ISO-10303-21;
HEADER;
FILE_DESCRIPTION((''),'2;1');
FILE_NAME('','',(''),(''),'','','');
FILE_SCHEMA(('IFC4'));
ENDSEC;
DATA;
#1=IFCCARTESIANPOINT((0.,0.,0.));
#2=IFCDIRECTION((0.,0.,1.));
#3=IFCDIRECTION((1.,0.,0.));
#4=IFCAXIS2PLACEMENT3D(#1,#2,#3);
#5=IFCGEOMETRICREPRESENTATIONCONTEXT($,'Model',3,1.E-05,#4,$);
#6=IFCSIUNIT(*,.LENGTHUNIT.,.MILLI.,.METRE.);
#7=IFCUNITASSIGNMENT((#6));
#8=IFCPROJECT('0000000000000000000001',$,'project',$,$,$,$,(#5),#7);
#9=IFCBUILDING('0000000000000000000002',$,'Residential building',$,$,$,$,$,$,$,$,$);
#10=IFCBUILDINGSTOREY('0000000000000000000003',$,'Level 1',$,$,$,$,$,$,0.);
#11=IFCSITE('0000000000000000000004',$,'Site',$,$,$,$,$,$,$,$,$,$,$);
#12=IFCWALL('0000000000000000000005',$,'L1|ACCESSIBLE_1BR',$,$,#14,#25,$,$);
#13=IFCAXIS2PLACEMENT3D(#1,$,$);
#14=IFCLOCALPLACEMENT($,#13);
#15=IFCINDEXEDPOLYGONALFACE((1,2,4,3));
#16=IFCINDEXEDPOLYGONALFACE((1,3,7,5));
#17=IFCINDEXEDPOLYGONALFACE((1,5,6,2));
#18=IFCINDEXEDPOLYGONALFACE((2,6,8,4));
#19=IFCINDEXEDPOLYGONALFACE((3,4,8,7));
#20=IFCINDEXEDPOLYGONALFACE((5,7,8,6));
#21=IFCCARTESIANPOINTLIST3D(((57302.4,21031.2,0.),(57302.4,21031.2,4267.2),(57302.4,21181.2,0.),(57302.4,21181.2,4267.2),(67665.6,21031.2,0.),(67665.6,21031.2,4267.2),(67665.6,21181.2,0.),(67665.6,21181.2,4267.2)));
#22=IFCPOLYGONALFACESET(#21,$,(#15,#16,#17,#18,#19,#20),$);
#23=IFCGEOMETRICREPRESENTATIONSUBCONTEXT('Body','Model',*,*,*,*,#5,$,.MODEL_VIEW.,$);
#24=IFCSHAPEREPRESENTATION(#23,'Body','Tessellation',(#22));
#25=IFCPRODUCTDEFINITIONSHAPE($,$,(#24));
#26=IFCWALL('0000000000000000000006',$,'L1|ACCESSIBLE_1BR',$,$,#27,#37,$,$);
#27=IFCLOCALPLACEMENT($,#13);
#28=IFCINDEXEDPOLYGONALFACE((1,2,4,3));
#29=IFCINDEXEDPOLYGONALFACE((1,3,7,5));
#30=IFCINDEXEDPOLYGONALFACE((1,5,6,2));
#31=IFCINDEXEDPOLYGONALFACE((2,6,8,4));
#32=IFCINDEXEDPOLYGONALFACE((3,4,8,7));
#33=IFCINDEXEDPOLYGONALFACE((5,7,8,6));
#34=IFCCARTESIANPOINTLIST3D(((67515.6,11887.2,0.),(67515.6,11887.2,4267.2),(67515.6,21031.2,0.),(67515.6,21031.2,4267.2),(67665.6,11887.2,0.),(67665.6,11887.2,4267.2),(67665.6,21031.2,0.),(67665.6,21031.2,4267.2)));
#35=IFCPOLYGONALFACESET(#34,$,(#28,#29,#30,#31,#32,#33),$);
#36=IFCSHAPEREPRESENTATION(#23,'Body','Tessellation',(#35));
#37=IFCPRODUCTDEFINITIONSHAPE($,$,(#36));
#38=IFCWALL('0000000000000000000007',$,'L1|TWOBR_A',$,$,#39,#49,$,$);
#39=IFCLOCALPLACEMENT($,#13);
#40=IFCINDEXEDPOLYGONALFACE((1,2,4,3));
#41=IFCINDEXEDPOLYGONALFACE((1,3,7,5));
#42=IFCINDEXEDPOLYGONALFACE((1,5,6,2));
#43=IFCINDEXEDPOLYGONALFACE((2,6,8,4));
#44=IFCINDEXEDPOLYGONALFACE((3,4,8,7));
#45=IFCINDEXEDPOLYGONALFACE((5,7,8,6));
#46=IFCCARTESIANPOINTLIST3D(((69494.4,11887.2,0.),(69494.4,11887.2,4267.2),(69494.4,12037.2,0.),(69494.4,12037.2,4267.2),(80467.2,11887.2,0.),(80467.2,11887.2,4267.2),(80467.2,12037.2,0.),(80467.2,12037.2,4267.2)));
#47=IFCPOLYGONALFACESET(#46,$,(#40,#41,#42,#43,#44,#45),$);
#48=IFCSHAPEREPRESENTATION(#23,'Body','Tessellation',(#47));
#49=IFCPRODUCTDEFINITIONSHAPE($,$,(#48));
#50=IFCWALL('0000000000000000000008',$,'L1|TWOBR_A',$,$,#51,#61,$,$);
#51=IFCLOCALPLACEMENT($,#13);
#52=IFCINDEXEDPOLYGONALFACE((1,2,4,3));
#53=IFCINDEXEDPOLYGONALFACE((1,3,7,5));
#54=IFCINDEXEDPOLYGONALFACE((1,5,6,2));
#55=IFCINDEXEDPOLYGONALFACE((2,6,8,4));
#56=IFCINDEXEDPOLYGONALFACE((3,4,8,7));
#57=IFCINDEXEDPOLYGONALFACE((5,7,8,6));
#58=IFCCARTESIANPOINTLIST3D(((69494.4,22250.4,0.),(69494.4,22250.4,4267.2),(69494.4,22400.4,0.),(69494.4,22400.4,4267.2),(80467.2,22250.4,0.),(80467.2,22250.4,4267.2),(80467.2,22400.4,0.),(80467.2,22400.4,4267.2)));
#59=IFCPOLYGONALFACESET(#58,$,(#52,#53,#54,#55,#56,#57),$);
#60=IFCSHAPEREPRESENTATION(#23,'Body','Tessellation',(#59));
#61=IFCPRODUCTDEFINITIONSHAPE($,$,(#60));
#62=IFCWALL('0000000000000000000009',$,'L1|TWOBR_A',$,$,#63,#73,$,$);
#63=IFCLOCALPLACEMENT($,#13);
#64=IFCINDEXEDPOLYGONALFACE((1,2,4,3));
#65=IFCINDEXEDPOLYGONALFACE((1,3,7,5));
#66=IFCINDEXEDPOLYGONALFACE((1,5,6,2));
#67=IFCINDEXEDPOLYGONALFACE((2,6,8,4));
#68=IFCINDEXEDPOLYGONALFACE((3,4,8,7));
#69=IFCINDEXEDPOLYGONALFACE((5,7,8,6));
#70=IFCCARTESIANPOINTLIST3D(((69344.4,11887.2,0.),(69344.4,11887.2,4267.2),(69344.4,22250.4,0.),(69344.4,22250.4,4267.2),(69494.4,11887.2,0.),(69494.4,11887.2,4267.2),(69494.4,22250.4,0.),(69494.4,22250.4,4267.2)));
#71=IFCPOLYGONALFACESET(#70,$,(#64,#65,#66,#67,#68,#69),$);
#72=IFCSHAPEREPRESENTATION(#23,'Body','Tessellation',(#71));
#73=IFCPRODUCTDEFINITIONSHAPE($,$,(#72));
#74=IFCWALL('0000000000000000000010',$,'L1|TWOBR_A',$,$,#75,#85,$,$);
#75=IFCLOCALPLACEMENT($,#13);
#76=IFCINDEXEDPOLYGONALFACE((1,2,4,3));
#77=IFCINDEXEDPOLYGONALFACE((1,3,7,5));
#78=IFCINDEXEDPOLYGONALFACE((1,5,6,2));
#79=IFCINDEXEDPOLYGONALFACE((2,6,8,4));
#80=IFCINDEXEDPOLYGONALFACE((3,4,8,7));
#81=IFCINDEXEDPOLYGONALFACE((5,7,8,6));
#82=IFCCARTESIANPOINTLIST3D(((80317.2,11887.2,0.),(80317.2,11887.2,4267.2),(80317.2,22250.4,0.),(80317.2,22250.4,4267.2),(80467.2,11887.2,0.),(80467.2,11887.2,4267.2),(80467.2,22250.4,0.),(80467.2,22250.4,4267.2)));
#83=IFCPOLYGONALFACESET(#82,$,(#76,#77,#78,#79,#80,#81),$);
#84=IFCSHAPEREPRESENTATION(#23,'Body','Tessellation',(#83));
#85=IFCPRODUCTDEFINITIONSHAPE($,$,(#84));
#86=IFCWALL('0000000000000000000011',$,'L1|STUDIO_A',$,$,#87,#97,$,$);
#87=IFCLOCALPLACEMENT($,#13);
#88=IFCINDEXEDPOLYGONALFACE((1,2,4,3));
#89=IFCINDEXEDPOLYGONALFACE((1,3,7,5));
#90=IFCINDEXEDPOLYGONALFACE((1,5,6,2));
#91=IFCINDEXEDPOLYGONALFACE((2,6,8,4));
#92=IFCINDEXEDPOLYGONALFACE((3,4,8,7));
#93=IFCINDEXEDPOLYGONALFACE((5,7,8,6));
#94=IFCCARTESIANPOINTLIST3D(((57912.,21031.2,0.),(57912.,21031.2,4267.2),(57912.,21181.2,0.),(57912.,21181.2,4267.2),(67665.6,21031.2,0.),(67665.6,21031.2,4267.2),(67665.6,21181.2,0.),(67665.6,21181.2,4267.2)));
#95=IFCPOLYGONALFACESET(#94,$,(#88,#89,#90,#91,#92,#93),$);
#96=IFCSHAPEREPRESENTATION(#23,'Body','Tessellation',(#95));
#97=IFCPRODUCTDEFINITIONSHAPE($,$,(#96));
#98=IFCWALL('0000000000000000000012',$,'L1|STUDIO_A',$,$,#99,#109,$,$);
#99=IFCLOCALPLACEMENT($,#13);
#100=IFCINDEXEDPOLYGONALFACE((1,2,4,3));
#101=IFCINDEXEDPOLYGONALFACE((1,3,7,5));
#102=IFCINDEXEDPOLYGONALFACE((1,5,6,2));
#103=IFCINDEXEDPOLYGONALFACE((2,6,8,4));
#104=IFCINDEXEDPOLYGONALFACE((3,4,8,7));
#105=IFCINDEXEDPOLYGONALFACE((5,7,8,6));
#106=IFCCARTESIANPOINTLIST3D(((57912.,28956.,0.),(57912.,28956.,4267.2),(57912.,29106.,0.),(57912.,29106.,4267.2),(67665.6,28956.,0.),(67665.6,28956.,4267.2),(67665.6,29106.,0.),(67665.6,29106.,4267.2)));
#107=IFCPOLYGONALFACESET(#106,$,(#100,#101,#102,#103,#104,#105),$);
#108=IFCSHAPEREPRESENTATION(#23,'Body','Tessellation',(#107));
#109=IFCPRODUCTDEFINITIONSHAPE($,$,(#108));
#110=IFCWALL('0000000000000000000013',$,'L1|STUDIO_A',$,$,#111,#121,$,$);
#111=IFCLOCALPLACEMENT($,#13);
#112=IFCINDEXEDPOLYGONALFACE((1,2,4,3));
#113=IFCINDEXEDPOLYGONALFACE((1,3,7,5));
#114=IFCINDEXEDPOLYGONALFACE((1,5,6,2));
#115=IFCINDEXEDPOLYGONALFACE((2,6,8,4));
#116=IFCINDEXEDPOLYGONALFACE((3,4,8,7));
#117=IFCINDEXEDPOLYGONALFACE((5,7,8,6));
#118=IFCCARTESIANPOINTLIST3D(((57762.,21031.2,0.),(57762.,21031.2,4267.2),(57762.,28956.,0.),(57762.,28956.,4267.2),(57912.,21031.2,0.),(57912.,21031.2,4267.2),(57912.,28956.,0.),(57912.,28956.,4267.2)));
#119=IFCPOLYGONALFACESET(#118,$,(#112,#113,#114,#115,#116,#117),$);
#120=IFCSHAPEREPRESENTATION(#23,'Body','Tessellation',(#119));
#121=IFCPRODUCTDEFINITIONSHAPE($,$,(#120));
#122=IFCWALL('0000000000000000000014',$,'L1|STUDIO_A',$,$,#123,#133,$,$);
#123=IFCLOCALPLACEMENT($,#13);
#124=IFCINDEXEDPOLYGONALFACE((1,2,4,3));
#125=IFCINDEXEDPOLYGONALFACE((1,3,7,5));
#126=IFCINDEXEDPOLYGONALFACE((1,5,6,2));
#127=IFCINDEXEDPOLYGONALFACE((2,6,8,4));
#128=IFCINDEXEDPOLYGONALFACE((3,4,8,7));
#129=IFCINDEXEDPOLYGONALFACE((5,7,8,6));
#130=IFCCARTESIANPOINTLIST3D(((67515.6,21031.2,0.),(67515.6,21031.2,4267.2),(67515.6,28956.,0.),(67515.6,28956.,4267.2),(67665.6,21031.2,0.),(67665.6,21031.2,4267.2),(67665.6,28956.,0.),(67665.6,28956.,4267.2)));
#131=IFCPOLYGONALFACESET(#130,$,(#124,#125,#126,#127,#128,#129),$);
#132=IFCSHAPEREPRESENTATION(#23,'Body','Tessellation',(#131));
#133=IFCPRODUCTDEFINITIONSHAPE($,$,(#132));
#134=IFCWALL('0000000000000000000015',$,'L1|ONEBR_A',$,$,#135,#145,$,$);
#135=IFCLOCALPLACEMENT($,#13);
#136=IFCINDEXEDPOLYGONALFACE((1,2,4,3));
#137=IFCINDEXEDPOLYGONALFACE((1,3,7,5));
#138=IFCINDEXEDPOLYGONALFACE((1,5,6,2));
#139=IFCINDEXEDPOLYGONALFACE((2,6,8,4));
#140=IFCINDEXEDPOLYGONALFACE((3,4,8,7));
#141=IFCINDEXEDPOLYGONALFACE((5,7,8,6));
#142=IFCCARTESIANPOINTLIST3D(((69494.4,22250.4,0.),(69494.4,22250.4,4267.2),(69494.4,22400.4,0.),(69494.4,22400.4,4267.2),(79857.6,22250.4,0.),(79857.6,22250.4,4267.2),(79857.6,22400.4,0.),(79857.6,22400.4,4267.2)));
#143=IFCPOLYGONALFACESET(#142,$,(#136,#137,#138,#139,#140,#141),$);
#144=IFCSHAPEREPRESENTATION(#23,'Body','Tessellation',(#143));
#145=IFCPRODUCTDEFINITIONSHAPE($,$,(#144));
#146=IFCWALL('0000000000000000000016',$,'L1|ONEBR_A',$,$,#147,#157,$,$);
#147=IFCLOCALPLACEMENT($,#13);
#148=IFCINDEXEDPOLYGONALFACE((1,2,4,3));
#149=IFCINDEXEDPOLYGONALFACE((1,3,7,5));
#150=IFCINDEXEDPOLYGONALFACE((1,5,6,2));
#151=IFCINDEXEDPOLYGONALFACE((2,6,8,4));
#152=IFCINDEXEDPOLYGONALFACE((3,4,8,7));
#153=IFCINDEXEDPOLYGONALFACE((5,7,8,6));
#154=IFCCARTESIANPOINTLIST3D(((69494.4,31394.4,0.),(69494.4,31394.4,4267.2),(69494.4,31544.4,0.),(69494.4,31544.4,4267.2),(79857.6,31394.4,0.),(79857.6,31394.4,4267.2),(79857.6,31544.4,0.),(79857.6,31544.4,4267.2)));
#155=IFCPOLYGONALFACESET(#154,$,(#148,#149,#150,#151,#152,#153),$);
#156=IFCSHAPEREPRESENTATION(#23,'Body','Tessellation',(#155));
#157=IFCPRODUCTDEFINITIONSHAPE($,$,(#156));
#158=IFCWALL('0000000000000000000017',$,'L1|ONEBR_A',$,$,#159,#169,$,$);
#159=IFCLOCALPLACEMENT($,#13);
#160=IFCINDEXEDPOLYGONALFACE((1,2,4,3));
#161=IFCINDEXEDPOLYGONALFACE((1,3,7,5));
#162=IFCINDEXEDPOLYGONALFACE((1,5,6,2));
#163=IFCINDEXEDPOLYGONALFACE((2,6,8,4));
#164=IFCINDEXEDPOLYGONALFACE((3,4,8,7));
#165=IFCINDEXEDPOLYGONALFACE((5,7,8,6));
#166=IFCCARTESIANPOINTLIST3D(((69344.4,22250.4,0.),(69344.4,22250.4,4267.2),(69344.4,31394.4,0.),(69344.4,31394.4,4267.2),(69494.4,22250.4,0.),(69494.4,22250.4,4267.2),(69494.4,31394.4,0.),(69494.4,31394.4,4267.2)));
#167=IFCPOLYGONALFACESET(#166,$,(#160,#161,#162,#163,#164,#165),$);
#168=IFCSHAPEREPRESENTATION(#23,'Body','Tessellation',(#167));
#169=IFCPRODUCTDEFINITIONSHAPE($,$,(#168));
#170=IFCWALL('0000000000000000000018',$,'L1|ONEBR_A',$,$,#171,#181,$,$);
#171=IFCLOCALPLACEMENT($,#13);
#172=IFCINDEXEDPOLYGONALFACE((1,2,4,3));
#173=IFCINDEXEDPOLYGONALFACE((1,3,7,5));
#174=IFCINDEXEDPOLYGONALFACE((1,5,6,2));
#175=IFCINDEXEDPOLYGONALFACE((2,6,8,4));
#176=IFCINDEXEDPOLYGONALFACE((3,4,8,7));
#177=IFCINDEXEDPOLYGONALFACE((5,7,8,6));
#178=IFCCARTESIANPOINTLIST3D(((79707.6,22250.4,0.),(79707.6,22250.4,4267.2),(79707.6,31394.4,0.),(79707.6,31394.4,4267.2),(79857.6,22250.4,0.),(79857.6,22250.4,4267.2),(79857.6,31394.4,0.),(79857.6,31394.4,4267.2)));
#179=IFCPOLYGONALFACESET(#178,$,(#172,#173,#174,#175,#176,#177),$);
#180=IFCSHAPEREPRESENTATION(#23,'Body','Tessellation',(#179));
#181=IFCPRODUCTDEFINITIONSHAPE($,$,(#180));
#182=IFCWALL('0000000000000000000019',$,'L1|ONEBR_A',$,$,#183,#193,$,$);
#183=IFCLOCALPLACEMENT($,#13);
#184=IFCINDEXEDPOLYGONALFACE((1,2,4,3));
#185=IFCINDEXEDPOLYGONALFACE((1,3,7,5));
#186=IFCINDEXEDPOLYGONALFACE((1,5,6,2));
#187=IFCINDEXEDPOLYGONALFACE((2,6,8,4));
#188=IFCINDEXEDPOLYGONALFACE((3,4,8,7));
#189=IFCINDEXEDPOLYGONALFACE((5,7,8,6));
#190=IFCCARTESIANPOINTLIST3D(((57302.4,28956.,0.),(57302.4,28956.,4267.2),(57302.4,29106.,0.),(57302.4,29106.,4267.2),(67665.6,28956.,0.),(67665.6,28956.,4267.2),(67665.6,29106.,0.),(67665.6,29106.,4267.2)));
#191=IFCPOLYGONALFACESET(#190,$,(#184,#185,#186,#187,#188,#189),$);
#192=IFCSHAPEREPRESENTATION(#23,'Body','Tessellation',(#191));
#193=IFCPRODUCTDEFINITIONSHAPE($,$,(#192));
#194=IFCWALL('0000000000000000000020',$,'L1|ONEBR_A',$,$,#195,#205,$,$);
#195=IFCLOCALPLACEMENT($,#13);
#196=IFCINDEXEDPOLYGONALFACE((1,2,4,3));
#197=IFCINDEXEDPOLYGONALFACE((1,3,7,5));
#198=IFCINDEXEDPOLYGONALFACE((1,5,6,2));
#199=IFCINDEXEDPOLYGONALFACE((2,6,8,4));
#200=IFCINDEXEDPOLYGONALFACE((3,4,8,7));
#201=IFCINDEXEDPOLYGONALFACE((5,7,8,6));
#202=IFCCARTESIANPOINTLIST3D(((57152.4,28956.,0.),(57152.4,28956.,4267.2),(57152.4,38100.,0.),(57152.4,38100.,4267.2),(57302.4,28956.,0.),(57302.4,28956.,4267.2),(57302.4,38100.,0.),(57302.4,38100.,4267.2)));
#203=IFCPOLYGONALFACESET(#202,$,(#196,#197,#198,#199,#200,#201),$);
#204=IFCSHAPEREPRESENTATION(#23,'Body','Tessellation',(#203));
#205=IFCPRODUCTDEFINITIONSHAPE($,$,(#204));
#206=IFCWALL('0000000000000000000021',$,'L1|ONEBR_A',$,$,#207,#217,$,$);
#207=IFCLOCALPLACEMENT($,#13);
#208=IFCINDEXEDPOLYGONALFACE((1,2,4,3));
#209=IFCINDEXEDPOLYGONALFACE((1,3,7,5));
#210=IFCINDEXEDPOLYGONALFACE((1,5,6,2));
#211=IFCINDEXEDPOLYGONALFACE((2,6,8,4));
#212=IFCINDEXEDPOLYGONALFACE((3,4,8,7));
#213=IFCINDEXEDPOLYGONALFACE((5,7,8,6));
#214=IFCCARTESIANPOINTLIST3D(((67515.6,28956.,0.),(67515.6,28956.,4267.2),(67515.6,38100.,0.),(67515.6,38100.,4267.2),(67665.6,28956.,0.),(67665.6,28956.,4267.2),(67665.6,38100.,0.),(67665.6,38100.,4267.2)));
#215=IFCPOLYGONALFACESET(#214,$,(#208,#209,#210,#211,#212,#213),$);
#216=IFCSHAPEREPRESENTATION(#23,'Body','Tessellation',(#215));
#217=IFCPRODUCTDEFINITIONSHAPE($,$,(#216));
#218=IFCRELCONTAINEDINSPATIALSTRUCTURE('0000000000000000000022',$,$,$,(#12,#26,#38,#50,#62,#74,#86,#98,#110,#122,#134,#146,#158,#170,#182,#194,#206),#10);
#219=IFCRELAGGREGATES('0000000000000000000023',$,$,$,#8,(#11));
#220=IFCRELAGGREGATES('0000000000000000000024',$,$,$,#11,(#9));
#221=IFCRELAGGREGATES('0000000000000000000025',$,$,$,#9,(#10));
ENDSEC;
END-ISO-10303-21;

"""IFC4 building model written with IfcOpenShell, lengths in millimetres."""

from ifc_helpers import new_model, si_unit, frame, origin_with_axes, place, context, subcontext, project, spatial, indexed_curve, outline, extrude, element, save


model = new_model("IFC4")

# Units and contexts
model_context = context("Model", 3, precision=1e-05, world=origin_with_axes())
body_context = subcontext(model_context, "Body", "Model", "MODEL_VIEW")
ifc_project = project(units=[si_unit("LENGTHUNIT", "METRE", prefix="MILLI")], contexts=[model_context])

# Site, building, storey
site = spatial("IfcSite", under=ifc_project, Name="Site")
building = spatial("IfcBuilding", under=site, Name="Residential building")
storey = spatial("IfcBuildingStorey", under=building, Name="Level 1", Elevation=0.0)

# Walls
wall_1_placement = place(None, frame((57302.4, 21031.2, 0.0), z_axis=(0.0, 0.0, 1.0), x_axis=(1.0, 0.0, 0.0)))
element("IfcWall", 1, at=wall_1_placement, inside=storey, Name="L1|ACCESSIBLE_1BR", context=body_context, shape_type="SweptSolid", body=[
    extrude(outline(indexed_curve([(0.0, 0.0), (0.0, 150.0), (10363.2, 150.0), (10363.2, 0.0), (0.0, 0.0)], self_intersect=False)), origin_with_axes(), (0.0, 0.0, 1.0), 4267.2),
])
wall_2_placement = place(None, frame((67665.6, 11887.2, 0.0), z_axis=(0.0, 0.0, 1.0), x_axis=(0.0, 1.0, 0.0)))
element("IfcWall", 2, at=wall_2_placement, inside=storey, Name="L1|ACCESSIBLE_1BR", context=body_context, shape_type="SweptSolid", body=[
    extrude(outline(indexed_curve([(0.0, 0.0), (0.0, 150.0), (9144.0, 150.0), (9144.0, 0.0), (0.0, 0.0)], self_intersect=False)), origin_with_axes(), (0.0, 0.0, 1.0), 4267.2),
])
for number, where, z_axis, x_axis, name in (
    (3, (69494.4, 11887.2, 0.0), (0.0, 0.0, 1.0), (1.0, 0.0, 0.0), "L1|TWOBR_A"),
    (4, (69494.4, 22250.4, 0.0), (0.0, 0.0, 1.0), (1.0, 0.0, 0.0), "L1|TWOBR_A"),
):
    element("IfcWall", number, at=place(None, frame(where, z_axis=z_axis, x_axis=x_axis)), inside=storey, Name=name, context=body_context, shape_type="SweptSolid", body=[
        extrude(outline(indexed_curve([(0.0, 0.0), (0.0, 150.0), (10972.8, 150.0), (10972.8, 0.0), (0.0, 0.0)], self_intersect=False)), origin_with_axes(), (0.0, 0.0, 1.0), 4267.2),
    ])
for number, where, z_axis, x_axis, name in (
    (5, (69494.4, 11887.2, 0.0), (0.0, 0.0, 1.0), (0.0, 1.0, 0.0), "L1|TWOBR_A"),
    (6, (80467.2, 11887.2, 0.0), (0.0, 0.0, 1.0), (0.0, 1.0, 0.0), "L1|TWOBR_A"),
):
    element("IfcWall", number, at=place(None, frame(where, z_axis=z_axis, x_axis=x_axis)), inside=storey, Name=name, context=body_context, shape_type="SweptSolid", body=[
        extrude(outline(indexed_curve([(0.0, 0.0), (0.0, 150.0), (10363.2, 150.0), (10363.2, 0.0), (0.0, 0.0)], self_intersect=False)), origin_with_axes(), (0.0, 0.0, 1.0), 4267.2),
    ])
for number, where, z_axis, x_axis, name in (
    (7, (57912.0, 21031.2, 0.0), (0.0, 0.0, 1.0), (1.0, 0.0, 0.0), "L1|STUDIO_A"),
    (8, (57912.0, 28956.0, 0.0), (0.0, 0.0, 1.0), (1.0, 0.0, 0.0), "L1|STUDIO_A"),
):
    element("IfcWall", number, at=place(None, frame(where, z_axis=z_axis, x_axis=x_axis)), inside=storey, Name=name, context=body_context, shape_type="SweptSolid", body=[
        extrude(outline(indexed_curve([(0.0, 0.0), (0.0, 150.0), (9753.6, 150.0), (9753.6, 0.0), (0.0, 0.0)], self_intersect=False)), origin_with_axes(), (0.0, 0.0, 1.0), 4267.2),
    ])
for number, where, z_axis, x_axis, name in (
    (9, (57912.0, 21031.2, 0.0), (0.0, 0.0, 1.0), (0.0, 1.0, 0.0), "L1|STUDIO_A"),
    (10, (67665.6, 21031.2, 0.0), (0.0, 0.0, 1.0), (0.0, 1.0, 0.0), "L1|STUDIO_A"),
):
    element("IfcWall", number, at=place(None, frame(where, z_axis=z_axis, x_axis=x_axis)), inside=storey, Name=name, context=body_context, shape_type="SweptSolid", body=[
        extrude(outline(indexed_curve([(0.0, 0.0), (0.0, 150.0), (7924.8, 150.0), (7924.8, 0.0), (0.0, 0.0)], self_intersect=False)), origin_with_axes(), (0.0, 0.0, 1.0), 4267.2),
    ])
for number, where, z_axis, x_axis, name in (
    (11, (69494.4, 22250.4, 0.0), (0.0, 0.0, 1.0), (1.0, 0.0, 0.0), "L1|ONEBR_A"),
    (12, (69494.4, 31394.4, 0.0), (0.0, 0.0, 1.0), (1.0, 0.0, 0.0), "L1|ONEBR_A"),
):
    element("IfcWall", number, at=place(None, frame(where, z_axis=z_axis, x_axis=x_axis)), inside=storey, Name=name, context=body_context, shape_type="SweptSolid", body=[
        extrude(outline(indexed_curve([(0.0, 0.0), (0.0, 150.0), (10363.2, 150.0), (10363.2, 0.0), (0.0, 0.0)], self_intersect=False)), origin_with_axes(), (0.0, 0.0, 1.0), 4267.2),
    ])
for number, where, z_axis, x_axis, name in (
    (13, (69494.4, 22250.4, 0.0), (0.0, 0.0, 1.0), (0.0, 1.0, 0.0), "L1|ONEBR_A"),
    (14, (79857.6, 22250.4, 0.0), (0.0, 0.0, 1.0), (0.0, 1.0, 0.0), "L1|ONEBR_A"),
):
    element("IfcWall", number, at=place(None, frame(where, z_axis=z_axis, x_axis=x_axis)), inside=storey, Name=name, context=body_context, shape_type="SweptSolid", body=[
        extrude(outline(indexed_curve([(0.0, 0.0), (0.0, 150.0), (9144.0, 150.0), (9144.0, 0.0), (0.0, 0.0)], self_intersect=False)), origin_with_axes(), (0.0, 0.0, 1.0), 4267.2),
    ])
wall_3_placement = place(None, frame((57302.4, 28956.0, 0.0), z_axis=(0.0, 0.0, 1.0), x_axis=(1.0, 0.0, 0.0)))
element("IfcWall", 15, at=wall_3_placement, inside=storey, Name="L1|ONEBR_A", context=body_context, shape_type="SweptSolid", body=[
    extrude(outline(indexed_curve([(0.0, 0.0), (0.0, 150.0), (10363.2, 150.0), (10363.2, 0.0), (0.0, 0.0)], self_intersect=False)), origin_with_axes(), (0.0, 0.0, 1.0), 4267.2),
])
for number, where, z_axis, x_axis, name in (
    (16, (57302.4, 28956.0, 0.0), (0.0, 0.0, 1.0), (0.0, 1.0, 0.0), "L1|ONEBR_A"),
    (17, (67665.6, 28956.0, 0.0), (0.0, 0.0, 1.0), (0.0, 1.0, 0.0), "L1|ONEBR_A"),
):
    element("IfcWall", number, at=place(None, frame(where, z_axis=z_axis, x_axis=x_axis)), inside=storey, Name=name, context=body_context, shape_type="SweptSolid", body=[
        extrude(outline(indexed_curve([(0.0, 0.0), (0.0, 150.0), (9144.0, 150.0), (9144.0, 0.0), (0.0, 0.0)], self_intersect=False)), origin_with_axes(), (0.0, 0.0, 1.0), 4267.2),
    ])

save(model, "model.ifc")
